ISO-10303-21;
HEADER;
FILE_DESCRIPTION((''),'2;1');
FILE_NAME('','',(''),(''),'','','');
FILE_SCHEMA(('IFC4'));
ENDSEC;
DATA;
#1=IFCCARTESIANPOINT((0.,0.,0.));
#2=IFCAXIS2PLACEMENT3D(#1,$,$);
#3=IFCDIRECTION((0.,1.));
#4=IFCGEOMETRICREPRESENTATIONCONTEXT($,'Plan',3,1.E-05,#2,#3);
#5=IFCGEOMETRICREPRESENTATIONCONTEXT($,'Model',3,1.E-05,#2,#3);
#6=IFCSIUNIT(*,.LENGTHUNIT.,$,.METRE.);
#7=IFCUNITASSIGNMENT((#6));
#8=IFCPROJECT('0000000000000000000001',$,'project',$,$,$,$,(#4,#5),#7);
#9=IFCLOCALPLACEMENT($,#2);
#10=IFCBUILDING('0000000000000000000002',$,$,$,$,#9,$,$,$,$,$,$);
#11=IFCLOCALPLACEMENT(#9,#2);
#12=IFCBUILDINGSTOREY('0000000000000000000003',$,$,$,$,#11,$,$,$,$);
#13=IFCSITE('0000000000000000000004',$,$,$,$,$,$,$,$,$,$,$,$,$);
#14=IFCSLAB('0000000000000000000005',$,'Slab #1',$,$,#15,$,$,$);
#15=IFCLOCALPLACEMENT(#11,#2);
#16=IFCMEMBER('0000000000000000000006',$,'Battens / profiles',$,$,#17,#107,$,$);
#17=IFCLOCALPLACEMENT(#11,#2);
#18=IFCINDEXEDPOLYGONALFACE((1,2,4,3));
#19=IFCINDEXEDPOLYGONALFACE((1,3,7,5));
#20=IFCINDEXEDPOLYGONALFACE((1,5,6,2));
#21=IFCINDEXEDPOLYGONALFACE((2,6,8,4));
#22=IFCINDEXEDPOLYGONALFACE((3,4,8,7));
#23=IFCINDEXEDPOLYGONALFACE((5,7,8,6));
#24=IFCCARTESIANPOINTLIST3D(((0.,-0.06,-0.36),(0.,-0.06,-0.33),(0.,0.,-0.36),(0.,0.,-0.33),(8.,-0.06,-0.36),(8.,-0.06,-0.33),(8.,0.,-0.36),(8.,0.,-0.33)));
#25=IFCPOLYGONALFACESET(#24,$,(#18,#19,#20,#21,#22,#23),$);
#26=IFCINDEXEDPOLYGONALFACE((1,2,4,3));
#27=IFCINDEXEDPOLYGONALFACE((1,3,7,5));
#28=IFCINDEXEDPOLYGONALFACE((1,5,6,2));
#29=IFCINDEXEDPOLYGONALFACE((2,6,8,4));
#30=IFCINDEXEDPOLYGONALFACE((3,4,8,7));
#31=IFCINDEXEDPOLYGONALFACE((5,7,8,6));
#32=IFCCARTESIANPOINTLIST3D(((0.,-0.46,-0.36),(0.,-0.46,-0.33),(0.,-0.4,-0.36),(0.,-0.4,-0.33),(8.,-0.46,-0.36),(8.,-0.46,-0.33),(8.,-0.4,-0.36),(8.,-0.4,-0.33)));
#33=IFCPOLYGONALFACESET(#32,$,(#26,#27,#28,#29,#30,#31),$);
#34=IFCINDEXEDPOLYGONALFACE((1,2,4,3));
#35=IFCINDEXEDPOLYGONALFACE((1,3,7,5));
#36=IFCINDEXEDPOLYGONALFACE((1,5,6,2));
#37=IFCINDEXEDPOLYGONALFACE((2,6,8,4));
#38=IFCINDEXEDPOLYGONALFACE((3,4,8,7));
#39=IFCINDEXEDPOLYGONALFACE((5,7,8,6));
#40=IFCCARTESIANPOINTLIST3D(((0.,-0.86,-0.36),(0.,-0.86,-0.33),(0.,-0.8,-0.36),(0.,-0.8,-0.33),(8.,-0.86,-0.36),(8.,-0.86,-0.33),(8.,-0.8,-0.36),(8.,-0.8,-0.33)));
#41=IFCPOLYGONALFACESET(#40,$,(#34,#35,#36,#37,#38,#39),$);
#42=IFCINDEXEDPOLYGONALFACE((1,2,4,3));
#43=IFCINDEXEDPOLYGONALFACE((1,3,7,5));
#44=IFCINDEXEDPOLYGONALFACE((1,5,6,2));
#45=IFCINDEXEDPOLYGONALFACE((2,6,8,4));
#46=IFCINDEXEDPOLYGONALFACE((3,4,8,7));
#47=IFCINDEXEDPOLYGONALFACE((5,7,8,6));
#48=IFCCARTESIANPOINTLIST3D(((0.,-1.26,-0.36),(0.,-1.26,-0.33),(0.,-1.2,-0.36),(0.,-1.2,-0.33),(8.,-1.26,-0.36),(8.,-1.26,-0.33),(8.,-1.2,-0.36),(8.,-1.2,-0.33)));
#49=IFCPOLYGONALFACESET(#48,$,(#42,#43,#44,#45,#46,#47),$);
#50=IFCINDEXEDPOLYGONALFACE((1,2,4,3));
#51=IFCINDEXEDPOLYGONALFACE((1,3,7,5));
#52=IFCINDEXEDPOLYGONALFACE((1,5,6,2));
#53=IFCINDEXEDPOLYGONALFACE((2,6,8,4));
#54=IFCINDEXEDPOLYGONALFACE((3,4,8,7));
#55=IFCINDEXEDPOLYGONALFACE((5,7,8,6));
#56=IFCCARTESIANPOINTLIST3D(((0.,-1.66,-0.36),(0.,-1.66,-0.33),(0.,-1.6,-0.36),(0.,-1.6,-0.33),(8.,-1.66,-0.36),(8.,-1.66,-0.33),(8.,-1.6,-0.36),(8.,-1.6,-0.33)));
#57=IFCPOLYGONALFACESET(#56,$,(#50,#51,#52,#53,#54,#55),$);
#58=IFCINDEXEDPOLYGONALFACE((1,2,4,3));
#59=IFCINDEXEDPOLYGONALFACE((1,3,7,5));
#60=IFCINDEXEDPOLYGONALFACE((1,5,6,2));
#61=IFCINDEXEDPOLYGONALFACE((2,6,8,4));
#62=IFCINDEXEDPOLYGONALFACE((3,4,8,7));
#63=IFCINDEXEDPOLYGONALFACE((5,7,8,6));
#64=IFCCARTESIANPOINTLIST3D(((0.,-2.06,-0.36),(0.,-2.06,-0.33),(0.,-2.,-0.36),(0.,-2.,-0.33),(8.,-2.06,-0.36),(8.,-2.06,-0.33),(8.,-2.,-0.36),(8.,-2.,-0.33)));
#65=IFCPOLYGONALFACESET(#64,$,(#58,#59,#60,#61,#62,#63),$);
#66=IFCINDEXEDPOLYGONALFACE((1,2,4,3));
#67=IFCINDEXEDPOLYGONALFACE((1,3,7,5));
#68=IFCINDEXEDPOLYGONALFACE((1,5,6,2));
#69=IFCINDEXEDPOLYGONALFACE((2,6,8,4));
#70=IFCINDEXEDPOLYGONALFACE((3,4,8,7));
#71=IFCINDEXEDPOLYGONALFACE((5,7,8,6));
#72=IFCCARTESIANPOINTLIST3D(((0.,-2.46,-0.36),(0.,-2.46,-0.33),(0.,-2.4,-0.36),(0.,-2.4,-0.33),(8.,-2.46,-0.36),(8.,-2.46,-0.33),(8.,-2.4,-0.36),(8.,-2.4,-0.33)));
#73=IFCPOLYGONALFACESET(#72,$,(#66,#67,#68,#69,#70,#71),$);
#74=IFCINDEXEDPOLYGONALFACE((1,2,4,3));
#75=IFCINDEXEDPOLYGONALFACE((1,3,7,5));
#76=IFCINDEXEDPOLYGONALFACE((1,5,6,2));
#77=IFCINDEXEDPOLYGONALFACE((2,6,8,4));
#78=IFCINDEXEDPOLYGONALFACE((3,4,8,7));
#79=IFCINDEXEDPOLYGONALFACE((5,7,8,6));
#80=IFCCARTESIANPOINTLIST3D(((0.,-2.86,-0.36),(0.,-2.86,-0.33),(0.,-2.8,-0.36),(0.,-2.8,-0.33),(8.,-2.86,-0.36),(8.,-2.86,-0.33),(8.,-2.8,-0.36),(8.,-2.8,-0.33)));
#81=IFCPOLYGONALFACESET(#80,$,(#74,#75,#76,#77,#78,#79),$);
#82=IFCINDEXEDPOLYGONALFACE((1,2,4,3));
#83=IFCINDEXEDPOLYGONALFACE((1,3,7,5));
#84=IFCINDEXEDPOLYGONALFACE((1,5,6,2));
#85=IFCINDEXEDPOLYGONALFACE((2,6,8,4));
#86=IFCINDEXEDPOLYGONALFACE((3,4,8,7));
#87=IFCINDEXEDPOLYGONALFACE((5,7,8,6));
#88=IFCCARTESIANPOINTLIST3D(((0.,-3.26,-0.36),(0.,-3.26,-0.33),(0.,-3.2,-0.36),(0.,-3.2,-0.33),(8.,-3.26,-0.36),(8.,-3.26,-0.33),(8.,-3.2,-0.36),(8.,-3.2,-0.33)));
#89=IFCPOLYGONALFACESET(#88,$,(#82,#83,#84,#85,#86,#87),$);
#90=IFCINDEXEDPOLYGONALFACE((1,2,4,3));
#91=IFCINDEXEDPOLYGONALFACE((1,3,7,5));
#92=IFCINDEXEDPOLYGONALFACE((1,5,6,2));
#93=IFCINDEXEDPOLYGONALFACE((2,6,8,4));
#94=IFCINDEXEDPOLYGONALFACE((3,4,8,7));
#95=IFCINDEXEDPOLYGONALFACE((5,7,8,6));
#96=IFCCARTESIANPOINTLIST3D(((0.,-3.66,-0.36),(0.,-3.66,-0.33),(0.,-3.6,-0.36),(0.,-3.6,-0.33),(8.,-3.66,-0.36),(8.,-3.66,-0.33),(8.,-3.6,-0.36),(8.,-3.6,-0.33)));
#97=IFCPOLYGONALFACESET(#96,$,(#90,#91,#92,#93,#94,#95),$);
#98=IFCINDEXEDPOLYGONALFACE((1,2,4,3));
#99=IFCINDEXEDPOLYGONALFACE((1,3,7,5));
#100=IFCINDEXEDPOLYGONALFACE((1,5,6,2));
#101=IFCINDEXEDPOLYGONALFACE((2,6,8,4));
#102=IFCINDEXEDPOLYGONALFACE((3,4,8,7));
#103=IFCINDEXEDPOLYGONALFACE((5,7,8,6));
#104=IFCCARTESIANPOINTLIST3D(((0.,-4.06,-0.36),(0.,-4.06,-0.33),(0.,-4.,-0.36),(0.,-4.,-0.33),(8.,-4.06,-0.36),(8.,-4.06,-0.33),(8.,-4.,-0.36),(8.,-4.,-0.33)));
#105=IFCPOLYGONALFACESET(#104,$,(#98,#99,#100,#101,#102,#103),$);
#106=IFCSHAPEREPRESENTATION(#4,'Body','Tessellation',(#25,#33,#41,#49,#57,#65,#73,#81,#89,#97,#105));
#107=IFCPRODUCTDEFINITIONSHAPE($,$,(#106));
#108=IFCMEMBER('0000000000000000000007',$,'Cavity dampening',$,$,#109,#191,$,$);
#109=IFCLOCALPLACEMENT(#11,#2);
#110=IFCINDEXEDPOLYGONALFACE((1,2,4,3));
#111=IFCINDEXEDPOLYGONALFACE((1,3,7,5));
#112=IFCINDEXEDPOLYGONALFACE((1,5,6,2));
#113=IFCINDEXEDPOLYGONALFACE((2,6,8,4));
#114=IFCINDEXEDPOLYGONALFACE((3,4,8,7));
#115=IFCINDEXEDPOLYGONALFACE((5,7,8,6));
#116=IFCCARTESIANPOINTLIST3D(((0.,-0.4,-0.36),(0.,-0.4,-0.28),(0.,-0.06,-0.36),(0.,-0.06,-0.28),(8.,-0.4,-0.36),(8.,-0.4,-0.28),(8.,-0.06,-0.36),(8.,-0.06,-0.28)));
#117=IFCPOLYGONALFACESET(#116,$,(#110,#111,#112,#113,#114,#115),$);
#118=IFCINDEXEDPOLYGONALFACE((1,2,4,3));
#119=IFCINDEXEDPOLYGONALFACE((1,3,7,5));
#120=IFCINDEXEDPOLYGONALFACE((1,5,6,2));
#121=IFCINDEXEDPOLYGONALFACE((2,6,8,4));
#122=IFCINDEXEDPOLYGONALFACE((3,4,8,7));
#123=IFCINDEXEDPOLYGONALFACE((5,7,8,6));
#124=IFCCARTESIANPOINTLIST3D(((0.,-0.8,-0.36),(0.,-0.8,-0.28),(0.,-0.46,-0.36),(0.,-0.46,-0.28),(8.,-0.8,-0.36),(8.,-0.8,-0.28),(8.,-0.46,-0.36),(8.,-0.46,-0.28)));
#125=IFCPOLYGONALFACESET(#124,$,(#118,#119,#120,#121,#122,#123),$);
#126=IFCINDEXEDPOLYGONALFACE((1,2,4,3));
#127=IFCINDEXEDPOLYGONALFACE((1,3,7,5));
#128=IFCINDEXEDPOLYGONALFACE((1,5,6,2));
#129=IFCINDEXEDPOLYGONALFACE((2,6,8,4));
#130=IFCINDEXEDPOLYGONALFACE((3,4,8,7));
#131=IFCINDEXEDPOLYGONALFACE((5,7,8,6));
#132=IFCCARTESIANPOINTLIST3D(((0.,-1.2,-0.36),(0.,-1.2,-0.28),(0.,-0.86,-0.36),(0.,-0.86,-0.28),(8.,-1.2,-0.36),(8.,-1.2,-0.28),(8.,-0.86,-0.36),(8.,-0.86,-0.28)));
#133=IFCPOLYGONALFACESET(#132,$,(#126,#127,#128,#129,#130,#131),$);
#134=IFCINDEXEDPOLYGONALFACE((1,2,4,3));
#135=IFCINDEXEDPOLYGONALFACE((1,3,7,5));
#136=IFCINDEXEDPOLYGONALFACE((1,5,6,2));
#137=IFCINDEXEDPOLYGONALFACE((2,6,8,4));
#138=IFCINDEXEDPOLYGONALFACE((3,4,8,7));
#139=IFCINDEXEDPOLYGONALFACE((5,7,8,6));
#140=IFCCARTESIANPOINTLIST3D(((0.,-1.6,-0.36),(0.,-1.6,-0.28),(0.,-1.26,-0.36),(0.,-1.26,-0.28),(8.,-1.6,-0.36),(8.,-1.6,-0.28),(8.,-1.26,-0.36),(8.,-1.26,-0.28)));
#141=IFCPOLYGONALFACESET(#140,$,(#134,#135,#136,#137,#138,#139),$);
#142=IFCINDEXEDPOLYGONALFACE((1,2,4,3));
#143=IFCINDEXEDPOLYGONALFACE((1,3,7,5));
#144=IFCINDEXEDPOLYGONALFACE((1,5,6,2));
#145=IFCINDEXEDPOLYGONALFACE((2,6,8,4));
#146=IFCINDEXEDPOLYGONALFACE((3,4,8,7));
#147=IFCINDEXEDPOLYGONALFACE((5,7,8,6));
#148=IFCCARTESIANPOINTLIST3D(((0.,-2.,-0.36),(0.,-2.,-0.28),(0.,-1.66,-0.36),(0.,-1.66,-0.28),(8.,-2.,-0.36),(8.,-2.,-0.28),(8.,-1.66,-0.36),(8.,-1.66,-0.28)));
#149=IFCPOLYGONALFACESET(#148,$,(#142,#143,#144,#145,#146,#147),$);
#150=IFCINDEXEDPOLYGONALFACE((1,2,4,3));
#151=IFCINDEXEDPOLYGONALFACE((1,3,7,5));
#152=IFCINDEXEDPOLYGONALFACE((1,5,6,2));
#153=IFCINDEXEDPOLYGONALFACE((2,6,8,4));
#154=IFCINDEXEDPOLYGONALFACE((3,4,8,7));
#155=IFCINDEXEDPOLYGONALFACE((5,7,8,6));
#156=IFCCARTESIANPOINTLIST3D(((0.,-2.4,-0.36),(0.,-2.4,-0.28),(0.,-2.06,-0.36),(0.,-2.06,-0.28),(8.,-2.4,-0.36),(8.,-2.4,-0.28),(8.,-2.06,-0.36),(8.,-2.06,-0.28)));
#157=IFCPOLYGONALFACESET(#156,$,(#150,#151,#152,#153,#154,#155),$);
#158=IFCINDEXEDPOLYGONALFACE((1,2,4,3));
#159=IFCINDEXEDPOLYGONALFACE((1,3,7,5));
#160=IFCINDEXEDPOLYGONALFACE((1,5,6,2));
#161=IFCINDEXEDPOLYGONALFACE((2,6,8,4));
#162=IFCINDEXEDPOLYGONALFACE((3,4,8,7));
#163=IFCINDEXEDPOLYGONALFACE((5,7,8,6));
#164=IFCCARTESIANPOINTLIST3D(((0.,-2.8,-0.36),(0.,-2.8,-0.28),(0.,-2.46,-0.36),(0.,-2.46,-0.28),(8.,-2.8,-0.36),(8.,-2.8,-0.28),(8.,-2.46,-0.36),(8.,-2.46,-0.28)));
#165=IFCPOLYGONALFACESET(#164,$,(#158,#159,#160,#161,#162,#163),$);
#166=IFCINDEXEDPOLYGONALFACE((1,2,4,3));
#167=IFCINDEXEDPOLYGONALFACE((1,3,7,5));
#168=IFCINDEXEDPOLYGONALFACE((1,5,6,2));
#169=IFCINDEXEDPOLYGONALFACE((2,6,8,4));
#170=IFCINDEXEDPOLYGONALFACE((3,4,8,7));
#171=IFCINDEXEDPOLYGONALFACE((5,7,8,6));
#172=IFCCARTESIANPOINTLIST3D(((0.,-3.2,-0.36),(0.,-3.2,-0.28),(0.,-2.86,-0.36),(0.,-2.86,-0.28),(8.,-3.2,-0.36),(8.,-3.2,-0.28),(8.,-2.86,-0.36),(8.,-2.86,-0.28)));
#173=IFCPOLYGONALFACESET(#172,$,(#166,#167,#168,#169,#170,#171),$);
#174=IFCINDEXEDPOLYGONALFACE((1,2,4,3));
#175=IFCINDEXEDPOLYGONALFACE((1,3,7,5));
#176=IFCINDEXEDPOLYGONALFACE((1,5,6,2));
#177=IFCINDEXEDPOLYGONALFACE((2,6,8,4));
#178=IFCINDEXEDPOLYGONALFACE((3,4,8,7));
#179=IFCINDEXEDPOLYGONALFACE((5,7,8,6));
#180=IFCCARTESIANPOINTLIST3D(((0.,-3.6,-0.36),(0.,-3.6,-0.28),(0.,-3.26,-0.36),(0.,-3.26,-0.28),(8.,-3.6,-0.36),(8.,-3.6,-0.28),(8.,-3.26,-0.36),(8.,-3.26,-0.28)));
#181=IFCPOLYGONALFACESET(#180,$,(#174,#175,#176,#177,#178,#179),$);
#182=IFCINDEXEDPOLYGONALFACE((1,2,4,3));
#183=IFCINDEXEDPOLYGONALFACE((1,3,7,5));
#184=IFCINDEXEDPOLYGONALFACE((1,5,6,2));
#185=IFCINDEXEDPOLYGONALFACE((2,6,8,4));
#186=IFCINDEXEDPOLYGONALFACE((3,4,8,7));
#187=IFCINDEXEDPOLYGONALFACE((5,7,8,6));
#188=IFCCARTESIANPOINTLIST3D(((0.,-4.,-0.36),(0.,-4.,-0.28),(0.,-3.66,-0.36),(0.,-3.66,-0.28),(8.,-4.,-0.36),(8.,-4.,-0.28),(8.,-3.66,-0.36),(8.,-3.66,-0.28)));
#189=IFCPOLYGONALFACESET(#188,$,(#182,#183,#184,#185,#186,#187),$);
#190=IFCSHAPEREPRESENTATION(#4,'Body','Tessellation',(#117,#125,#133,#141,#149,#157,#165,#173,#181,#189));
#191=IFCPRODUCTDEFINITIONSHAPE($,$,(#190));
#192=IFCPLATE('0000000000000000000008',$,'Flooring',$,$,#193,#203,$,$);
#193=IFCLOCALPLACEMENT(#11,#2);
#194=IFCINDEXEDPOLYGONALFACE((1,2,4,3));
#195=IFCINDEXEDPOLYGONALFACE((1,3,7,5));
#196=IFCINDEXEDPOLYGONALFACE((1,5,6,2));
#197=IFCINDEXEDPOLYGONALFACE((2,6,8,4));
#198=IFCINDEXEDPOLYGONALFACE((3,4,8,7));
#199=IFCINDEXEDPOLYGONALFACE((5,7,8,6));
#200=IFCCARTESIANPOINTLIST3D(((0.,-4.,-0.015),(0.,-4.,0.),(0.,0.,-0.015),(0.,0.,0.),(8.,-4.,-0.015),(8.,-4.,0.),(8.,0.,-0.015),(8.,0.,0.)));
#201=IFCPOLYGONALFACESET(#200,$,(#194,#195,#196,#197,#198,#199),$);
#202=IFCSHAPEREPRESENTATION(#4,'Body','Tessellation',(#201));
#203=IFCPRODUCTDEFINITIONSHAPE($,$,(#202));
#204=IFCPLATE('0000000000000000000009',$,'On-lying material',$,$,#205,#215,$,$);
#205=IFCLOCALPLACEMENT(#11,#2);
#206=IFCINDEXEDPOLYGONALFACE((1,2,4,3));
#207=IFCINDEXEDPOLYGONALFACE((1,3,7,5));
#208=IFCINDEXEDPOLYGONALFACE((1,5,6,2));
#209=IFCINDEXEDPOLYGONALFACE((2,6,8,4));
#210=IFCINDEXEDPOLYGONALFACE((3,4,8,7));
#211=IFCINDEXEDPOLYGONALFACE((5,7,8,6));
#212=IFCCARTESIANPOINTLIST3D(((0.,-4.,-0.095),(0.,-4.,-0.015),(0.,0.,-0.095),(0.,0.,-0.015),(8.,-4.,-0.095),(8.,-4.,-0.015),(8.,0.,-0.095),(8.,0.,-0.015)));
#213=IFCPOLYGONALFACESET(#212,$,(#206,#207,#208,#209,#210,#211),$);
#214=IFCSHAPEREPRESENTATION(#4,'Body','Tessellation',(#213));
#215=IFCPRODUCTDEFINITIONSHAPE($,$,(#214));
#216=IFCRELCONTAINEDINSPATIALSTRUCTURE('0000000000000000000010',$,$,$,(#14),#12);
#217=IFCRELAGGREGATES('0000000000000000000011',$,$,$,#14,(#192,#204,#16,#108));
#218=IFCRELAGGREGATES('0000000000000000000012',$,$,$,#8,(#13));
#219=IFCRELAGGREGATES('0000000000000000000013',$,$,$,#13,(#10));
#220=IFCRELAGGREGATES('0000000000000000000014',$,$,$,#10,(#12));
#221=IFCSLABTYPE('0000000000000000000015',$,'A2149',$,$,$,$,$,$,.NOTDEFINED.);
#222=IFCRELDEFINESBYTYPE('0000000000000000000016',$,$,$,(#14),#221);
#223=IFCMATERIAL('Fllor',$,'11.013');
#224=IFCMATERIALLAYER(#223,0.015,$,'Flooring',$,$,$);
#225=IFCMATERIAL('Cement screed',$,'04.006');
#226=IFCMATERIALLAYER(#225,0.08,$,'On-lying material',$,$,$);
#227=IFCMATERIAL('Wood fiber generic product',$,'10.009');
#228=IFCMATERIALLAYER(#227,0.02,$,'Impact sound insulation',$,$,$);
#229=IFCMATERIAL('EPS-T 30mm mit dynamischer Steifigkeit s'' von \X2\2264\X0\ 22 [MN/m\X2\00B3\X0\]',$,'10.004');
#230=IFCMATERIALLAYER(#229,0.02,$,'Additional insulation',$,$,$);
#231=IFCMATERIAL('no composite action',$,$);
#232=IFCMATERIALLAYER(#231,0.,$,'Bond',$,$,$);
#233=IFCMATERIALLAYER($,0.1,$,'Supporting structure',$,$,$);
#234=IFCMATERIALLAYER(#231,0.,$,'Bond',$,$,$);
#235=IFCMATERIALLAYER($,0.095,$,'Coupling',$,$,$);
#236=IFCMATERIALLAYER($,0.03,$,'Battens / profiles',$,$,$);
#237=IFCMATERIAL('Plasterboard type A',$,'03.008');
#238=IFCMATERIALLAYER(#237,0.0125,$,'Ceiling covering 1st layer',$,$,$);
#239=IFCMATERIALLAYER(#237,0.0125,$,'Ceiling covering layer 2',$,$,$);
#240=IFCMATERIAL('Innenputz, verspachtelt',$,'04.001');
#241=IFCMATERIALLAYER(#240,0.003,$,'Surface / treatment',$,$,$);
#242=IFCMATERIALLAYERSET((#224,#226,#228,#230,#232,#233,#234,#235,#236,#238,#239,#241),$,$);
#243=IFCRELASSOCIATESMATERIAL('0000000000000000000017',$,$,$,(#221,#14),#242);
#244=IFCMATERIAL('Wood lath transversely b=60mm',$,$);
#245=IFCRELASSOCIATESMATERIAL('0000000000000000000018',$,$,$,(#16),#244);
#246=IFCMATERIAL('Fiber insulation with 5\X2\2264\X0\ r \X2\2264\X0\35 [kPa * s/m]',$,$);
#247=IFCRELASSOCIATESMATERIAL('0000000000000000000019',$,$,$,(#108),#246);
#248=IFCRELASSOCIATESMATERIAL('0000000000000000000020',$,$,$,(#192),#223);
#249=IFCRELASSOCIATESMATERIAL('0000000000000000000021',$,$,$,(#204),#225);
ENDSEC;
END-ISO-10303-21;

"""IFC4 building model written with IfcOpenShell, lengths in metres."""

from ifc_helpers import new_model, si_unit, direction, frame, frame_2d, origin, origin_with_axes, place, context, project, spatial, rectangle, extrude, material, layer, layer_set, type_object, element, aggregate, save


model = new_model("IFC4")

# Units and contexts
plan_context = context("Plan", 3, precision=1e-05, world=origin(), true_north=direction((0.0, 1.0)))
model_context = context("Model", 3, precision=1e-05, world=origin(), true_north=direction((0.0, 1.0)))
ifc_project = project(units=[si_unit("LENGTHUNIT", "METRE")], contexts=[plan_context, model_context])

# Site, building, storey
site = spatial("IfcSite", under=ifc_project)
building_placement = place(None, origin())
building = spatial("IfcBuilding", under=site, at=building_placement)
storey_placement = place(building_placement, origin())
storey = spatial("IfcBuildingStorey", under=building, at=storey_placement)

# Slab, members, plates
ifc_material_1 = material(Name="Fllor", Category="11.013")
ifc_layer_1 = layer(ifc_material_1, 0.015, Name="Flooring")
ifc_material_2 = material(Name="Cement screed", Category="04.006")
ifc_layer_2 = layer(ifc_material_2, 0.08, Name="On-lying material")
ifc_material_3 = material(Name="Wood fiber generic product", Category="10.009")
ifc_layer_3 = layer(ifc_material_3, 0.02, Name="Impact sound insulation")
ifc_material_4 = material(Name="EPS-T 30mm mit dynamischer Steifigkeit s' von ≤ 22 [MN/m³]", Category="10.004")
ifc_layer_4 = layer(ifc_material_4, 0.02, Name="Additional insulation")
ifc_material_5 = material(Name="no composite action")
ifc_layer_5 = layer(ifc_material_5, 0.0, Name="Bond")
ifc_layer_6 = layer(None, 0.1, Name="Supporting structure")
ifc_layer_7 = layer(ifc_material_5, 0.0, Name="Bond")
ifc_layer_8 = layer(None, 0.095, Name="Coupling")
ifc_layer_9 = layer(None, 0.03, Name="Battens / profiles")
ifc_material_6 = material(Name="Plasterboard type A", Category="03.008")
ifc_layer_10 = layer(ifc_material_6, 0.0125, Name="Ceiling covering 1st layer")
ifc_layer_11 = layer(ifc_material_6, 0.0125, Name="Ceiling covering layer 2")
ifc_material_7 = material(Name="Innenputz, verspachtelt", Category="04.001")
ifc_layer_12 = layer(ifc_material_7, 0.003, Name="Surface / treatment")
ifc_layer_set = layer_set([ifc_layer_1, ifc_layer_2, ifc_layer_3, ifc_layer_4, ifc_layer_5, ifc_layer_6, ifc_layer_7, ifc_layer_8, ifc_layer_9, ifc_layer_10, ifc_layer_11, ifc_layer_12])
slab_type = type_object("IfcSlabType", Name="A2149", PredefinedType="NOTDEFINED", material=ifc_layer_set)
slab_placement = place(None, frame((0.0, 0.0, 0.0), z_axis=(0.0, 0.0, -1.0), x_axis=(1.0, 0.0, 0.0)))
slab = element("IfcSlab", 1, at=slab_placement, inside=storey, type_object=slab_type, material=ifc_layer_set, Name="Slab #1")
ifc_material_8 = material(Name="Wood lath transversely b=60mm")
member_1_placement = place(slab_placement, origin())
member_1 = element("IfcMember", 2, at=member_1_placement, material=ifc_material_8, Name="Battens / profiles", context=plan_context, shape_type="SweptSolid", body=[
    extrude(rectangle(XDim=0.06, YDim=0.03, at=frame_2d((0.03, 0.015), x_axis=(1.0, 0.0))), frame((0.0, 0.0, 0.33), z_axis=(1.0, 0.0, 0.0), x_axis=(0.0, 1.0, 0.0)), (0.0, 0.0, 1.0), 8.0),
    extrude(rectangle(XDim=0.06, YDim=0.03, at=frame_2d((0.03, 0.015), x_axis=(1.0, 0.0))), frame((0.0, 0.4, 0.33), z_axis=(1.0, 0.0, 0.0), x_axis=(0.0, 1.0, 0.0)), (0.0, 0.0, 1.0), 8.0),
    extrude(rectangle(XDim=0.06, YDim=0.03, at=frame_2d((0.03, 0.015), x_axis=(1.0, 0.0))), frame((0.0, 0.8, 0.33), z_axis=(1.0, 0.0, 0.0), x_axis=(0.0, 1.0, 0.0)), (0.0, 0.0, 1.0), 8.0),
    extrude(rectangle(XDim=0.06, YDim=0.03, at=frame_2d((0.03, 0.015), x_axis=(1.0, 0.0))), frame((0.0, 1.2, 0.33), z_axis=(1.0, 0.0, 0.0), x_axis=(0.0, 1.0, 0.0)), (0.0, 0.0, 1.0), 8.0),
    extrude(rectangle(XDim=0.06, YDim=0.03, at=frame_2d((0.03, 0.015), x_axis=(1.0, 0.0))), frame((0.0, 1.6, 0.33), z_axis=(1.0, 0.0, 0.0), x_axis=(0.0, 1.0, 0.0)), (0.0, 0.0, 1.0), 8.0),
    extrude(rectangle(XDim=0.06, YDim=0.03, at=frame_2d((0.03, 0.015), x_axis=(1.0, 0.0))), frame((0.0, 2.0, 0.33), z_axis=(1.0, 0.0, 0.0), x_axis=(0.0, 1.0, 0.0)), (0.0, 0.0, 1.0), 8.0),
    extrude(rectangle(XDim=0.06, YDim=0.03, at=frame_2d((0.03, 0.015), x_axis=(1.0, 0.0))), frame((0.0, 2.4, 0.33), z_axis=(1.0, 0.0, 0.0), x_axis=(0.0, 1.0, 0.0)), (0.0, 0.0, 1.0), 8.0),
    extrude(rectangle(XDim=0.06, YDim=0.03, at=frame_2d((0.03, 0.015), x_axis=(1.0, 0.0))), frame((0.0, 2.8, 0.33), z_axis=(1.0, 0.0, 0.0), x_axis=(0.0, 1.0, 0.0)), (0.0, 0.0, 1.0), 8.0),
    extrude(rectangle(XDim=0.06, YDim=0.03, at=frame_2d((0.03, 0.015), x_axis=(1.0, 0.0))), frame((0.0, 3.2, 0.33), z_axis=(1.0, 0.0, 0.0), x_axis=(0.0, 1.0, 0.0)), (0.0, 0.0, 1.0), 8.0),
    extrude(rectangle(XDim=0.06, YDim=0.03, at=frame_2d((0.03, 0.015), x_axis=(1.0, 0.0))), frame((0.0, 3.6, 0.33), z_axis=(1.0, 0.0, 0.0), x_axis=(0.0, 1.0, 0.0)), (0.0, 0.0, 1.0), 8.0),
    extrude(rectangle(XDim=0.06, YDim=0.03, at=frame_2d((0.03, 0.015), x_axis=(1.0, 0.0))), frame((0.0, 4.0, 0.33), z_axis=(1.0, 0.0, 0.0), x_axis=(0.0, 1.0, 0.0)), (0.0, 0.0, 1.0), 8.0),
])
ifc_material_9 = material(Name="Fiber insulation with 5≤ r ≤35 [kPa * s/m]")
member_2_placement = place(slab_placement, origin())
member_2 = element("IfcMember", 3, at=member_2_placement, material=ifc_material_9, Name="Cavity dampening", context=plan_context, shape_type="SweptSolid", body=[
    extrude(rectangle(XDim=0.34, YDim=0.08, at=frame_2d((0.17, 0.04), x_axis=(1.0, 0.0))), frame((0.0, 0.06, 0.28), z_axis=(1.0, 0.0, 0.0), x_axis=(0.0, 1.0, 0.0)), (0.0, 0.0, 1.0), 8.0),
    extrude(rectangle(XDim=0.34, YDim=0.08, at=frame_2d((0.17, 0.04), x_axis=(1.0, 0.0))), frame((0.0, 0.46, 0.28), z_axis=(1.0, 0.0, 0.0), x_axis=(0.0, 1.0, 0.0)), (0.0, 0.0, 1.0), 8.0),
    extrude(rectangle(XDim=0.34, YDim=0.08, at=frame_2d((0.17, 0.04), x_axis=(1.0, 0.0))), frame((0.0, 0.86, 0.28), z_axis=(1.0, 0.0, 0.0), x_axis=(0.0, 1.0, 0.0)), (0.0, 0.0, 1.0), 8.0),
    extrude(rectangle(XDim=0.34, YDim=0.08, at=frame_2d((0.17, 0.04), x_axis=(1.0, 0.0))), frame((0.0, 1.26, 0.28), z_axis=(1.0, 0.0, 0.0), x_axis=(0.0, 1.0, 0.0)), (0.0, 0.0, 1.0), 8.0),
    extrude(rectangle(XDim=0.34, YDim=0.08, at=frame_2d((0.17, 0.04), x_axis=(1.0, 0.0))), frame((0.0, 1.66, 0.28), z_axis=(1.0, 0.0, 0.0), x_axis=(0.0, 1.0, 0.0)), (0.0, 0.0, 1.0), 8.0),
    extrude(rectangle(XDim=0.34, YDim=0.08, at=frame_2d((0.17, 0.04), x_axis=(1.0, 0.0))), frame((0.0, 2.06, 0.28), z_axis=(1.0, 0.0, 0.0), x_axis=(0.0, 1.0, 0.0)), (0.0, 0.0, 1.0), 8.0),
    extrude(rectangle(XDim=0.34, YDim=0.08, at=frame_2d((0.17, 0.04), x_axis=(1.0, 0.0))), frame((0.0, 2.46, 0.28), z_axis=(1.0, 0.0, 0.0), x_axis=(0.0, 1.0, 0.0)), (0.0, 0.0, 1.0), 8.0),
    extrude(rectangle(XDim=0.34, YDim=0.08, at=frame_2d((0.17, 0.04), x_axis=(1.0, 0.0))), frame((0.0, 2.86, 0.28), z_axis=(1.0, 0.0, 0.0), x_axis=(0.0, 1.0, 0.0)), (0.0, 0.0, 1.0), 8.0),
    extrude(rectangle(XDim=0.34, YDim=0.08, at=frame_2d((0.17, 0.04), x_axis=(1.0, 0.0))), frame((0.0, 3.26, 0.28), z_axis=(1.0, 0.0, 0.0), x_axis=(0.0, 1.0, 0.0)), (0.0, 0.0, 1.0), 8.0),
    extrude(rectangle(XDim=0.34, YDim=0.08, at=frame_2d((0.17, 0.04), x_axis=(1.0, 0.0))), frame((0.0, 3.66, 0.28), z_axis=(1.0, 0.0, 0.0), x_axis=(0.0, 1.0, 0.0)), (0.0, 0.0, 1.0), 8.0),
])
plate_1_placement = place(slab_placement, origin())
plate_1 = element("IfcPlate", 4, at=plate_1_placement, material=ifc_material_1, Name="Flooring", context=plan_context, shape_type="SweptSolid", body=[
    extrude(rectangle(XDim=8.0, YDim=4.0, at=frame_2d((4.0, 2.0), x_axis=(1.0, 0.0))), origin_with_axes(), (0.0, 0.0, 1.0), 0.015),
])
plate_2_placement = place(slab_placement, origin())
plate_2 = element("IfcPlate", 5, at=plate_2_placement, material=ifc_material_2, Name="On-lying material", context=plan_context, shape_type="SweptSolid", body=[
    extrude(rectangle(XDim=8.0, YDim=4.0, at=frame_2d((4.0, 2.0), x_axis=(1.0, 0.0))), frame((0.0, 0.0, 0.015), z_axis=(0.0, 0.0, 1.0), x_axis=(1.0, 0.0, 0.0)), (0.0, 0.0, 1.0), 0.08),
])
aggregate(slab, [plate_1, plate_2, member_1, member_2])

save(model, "model.ifc")
